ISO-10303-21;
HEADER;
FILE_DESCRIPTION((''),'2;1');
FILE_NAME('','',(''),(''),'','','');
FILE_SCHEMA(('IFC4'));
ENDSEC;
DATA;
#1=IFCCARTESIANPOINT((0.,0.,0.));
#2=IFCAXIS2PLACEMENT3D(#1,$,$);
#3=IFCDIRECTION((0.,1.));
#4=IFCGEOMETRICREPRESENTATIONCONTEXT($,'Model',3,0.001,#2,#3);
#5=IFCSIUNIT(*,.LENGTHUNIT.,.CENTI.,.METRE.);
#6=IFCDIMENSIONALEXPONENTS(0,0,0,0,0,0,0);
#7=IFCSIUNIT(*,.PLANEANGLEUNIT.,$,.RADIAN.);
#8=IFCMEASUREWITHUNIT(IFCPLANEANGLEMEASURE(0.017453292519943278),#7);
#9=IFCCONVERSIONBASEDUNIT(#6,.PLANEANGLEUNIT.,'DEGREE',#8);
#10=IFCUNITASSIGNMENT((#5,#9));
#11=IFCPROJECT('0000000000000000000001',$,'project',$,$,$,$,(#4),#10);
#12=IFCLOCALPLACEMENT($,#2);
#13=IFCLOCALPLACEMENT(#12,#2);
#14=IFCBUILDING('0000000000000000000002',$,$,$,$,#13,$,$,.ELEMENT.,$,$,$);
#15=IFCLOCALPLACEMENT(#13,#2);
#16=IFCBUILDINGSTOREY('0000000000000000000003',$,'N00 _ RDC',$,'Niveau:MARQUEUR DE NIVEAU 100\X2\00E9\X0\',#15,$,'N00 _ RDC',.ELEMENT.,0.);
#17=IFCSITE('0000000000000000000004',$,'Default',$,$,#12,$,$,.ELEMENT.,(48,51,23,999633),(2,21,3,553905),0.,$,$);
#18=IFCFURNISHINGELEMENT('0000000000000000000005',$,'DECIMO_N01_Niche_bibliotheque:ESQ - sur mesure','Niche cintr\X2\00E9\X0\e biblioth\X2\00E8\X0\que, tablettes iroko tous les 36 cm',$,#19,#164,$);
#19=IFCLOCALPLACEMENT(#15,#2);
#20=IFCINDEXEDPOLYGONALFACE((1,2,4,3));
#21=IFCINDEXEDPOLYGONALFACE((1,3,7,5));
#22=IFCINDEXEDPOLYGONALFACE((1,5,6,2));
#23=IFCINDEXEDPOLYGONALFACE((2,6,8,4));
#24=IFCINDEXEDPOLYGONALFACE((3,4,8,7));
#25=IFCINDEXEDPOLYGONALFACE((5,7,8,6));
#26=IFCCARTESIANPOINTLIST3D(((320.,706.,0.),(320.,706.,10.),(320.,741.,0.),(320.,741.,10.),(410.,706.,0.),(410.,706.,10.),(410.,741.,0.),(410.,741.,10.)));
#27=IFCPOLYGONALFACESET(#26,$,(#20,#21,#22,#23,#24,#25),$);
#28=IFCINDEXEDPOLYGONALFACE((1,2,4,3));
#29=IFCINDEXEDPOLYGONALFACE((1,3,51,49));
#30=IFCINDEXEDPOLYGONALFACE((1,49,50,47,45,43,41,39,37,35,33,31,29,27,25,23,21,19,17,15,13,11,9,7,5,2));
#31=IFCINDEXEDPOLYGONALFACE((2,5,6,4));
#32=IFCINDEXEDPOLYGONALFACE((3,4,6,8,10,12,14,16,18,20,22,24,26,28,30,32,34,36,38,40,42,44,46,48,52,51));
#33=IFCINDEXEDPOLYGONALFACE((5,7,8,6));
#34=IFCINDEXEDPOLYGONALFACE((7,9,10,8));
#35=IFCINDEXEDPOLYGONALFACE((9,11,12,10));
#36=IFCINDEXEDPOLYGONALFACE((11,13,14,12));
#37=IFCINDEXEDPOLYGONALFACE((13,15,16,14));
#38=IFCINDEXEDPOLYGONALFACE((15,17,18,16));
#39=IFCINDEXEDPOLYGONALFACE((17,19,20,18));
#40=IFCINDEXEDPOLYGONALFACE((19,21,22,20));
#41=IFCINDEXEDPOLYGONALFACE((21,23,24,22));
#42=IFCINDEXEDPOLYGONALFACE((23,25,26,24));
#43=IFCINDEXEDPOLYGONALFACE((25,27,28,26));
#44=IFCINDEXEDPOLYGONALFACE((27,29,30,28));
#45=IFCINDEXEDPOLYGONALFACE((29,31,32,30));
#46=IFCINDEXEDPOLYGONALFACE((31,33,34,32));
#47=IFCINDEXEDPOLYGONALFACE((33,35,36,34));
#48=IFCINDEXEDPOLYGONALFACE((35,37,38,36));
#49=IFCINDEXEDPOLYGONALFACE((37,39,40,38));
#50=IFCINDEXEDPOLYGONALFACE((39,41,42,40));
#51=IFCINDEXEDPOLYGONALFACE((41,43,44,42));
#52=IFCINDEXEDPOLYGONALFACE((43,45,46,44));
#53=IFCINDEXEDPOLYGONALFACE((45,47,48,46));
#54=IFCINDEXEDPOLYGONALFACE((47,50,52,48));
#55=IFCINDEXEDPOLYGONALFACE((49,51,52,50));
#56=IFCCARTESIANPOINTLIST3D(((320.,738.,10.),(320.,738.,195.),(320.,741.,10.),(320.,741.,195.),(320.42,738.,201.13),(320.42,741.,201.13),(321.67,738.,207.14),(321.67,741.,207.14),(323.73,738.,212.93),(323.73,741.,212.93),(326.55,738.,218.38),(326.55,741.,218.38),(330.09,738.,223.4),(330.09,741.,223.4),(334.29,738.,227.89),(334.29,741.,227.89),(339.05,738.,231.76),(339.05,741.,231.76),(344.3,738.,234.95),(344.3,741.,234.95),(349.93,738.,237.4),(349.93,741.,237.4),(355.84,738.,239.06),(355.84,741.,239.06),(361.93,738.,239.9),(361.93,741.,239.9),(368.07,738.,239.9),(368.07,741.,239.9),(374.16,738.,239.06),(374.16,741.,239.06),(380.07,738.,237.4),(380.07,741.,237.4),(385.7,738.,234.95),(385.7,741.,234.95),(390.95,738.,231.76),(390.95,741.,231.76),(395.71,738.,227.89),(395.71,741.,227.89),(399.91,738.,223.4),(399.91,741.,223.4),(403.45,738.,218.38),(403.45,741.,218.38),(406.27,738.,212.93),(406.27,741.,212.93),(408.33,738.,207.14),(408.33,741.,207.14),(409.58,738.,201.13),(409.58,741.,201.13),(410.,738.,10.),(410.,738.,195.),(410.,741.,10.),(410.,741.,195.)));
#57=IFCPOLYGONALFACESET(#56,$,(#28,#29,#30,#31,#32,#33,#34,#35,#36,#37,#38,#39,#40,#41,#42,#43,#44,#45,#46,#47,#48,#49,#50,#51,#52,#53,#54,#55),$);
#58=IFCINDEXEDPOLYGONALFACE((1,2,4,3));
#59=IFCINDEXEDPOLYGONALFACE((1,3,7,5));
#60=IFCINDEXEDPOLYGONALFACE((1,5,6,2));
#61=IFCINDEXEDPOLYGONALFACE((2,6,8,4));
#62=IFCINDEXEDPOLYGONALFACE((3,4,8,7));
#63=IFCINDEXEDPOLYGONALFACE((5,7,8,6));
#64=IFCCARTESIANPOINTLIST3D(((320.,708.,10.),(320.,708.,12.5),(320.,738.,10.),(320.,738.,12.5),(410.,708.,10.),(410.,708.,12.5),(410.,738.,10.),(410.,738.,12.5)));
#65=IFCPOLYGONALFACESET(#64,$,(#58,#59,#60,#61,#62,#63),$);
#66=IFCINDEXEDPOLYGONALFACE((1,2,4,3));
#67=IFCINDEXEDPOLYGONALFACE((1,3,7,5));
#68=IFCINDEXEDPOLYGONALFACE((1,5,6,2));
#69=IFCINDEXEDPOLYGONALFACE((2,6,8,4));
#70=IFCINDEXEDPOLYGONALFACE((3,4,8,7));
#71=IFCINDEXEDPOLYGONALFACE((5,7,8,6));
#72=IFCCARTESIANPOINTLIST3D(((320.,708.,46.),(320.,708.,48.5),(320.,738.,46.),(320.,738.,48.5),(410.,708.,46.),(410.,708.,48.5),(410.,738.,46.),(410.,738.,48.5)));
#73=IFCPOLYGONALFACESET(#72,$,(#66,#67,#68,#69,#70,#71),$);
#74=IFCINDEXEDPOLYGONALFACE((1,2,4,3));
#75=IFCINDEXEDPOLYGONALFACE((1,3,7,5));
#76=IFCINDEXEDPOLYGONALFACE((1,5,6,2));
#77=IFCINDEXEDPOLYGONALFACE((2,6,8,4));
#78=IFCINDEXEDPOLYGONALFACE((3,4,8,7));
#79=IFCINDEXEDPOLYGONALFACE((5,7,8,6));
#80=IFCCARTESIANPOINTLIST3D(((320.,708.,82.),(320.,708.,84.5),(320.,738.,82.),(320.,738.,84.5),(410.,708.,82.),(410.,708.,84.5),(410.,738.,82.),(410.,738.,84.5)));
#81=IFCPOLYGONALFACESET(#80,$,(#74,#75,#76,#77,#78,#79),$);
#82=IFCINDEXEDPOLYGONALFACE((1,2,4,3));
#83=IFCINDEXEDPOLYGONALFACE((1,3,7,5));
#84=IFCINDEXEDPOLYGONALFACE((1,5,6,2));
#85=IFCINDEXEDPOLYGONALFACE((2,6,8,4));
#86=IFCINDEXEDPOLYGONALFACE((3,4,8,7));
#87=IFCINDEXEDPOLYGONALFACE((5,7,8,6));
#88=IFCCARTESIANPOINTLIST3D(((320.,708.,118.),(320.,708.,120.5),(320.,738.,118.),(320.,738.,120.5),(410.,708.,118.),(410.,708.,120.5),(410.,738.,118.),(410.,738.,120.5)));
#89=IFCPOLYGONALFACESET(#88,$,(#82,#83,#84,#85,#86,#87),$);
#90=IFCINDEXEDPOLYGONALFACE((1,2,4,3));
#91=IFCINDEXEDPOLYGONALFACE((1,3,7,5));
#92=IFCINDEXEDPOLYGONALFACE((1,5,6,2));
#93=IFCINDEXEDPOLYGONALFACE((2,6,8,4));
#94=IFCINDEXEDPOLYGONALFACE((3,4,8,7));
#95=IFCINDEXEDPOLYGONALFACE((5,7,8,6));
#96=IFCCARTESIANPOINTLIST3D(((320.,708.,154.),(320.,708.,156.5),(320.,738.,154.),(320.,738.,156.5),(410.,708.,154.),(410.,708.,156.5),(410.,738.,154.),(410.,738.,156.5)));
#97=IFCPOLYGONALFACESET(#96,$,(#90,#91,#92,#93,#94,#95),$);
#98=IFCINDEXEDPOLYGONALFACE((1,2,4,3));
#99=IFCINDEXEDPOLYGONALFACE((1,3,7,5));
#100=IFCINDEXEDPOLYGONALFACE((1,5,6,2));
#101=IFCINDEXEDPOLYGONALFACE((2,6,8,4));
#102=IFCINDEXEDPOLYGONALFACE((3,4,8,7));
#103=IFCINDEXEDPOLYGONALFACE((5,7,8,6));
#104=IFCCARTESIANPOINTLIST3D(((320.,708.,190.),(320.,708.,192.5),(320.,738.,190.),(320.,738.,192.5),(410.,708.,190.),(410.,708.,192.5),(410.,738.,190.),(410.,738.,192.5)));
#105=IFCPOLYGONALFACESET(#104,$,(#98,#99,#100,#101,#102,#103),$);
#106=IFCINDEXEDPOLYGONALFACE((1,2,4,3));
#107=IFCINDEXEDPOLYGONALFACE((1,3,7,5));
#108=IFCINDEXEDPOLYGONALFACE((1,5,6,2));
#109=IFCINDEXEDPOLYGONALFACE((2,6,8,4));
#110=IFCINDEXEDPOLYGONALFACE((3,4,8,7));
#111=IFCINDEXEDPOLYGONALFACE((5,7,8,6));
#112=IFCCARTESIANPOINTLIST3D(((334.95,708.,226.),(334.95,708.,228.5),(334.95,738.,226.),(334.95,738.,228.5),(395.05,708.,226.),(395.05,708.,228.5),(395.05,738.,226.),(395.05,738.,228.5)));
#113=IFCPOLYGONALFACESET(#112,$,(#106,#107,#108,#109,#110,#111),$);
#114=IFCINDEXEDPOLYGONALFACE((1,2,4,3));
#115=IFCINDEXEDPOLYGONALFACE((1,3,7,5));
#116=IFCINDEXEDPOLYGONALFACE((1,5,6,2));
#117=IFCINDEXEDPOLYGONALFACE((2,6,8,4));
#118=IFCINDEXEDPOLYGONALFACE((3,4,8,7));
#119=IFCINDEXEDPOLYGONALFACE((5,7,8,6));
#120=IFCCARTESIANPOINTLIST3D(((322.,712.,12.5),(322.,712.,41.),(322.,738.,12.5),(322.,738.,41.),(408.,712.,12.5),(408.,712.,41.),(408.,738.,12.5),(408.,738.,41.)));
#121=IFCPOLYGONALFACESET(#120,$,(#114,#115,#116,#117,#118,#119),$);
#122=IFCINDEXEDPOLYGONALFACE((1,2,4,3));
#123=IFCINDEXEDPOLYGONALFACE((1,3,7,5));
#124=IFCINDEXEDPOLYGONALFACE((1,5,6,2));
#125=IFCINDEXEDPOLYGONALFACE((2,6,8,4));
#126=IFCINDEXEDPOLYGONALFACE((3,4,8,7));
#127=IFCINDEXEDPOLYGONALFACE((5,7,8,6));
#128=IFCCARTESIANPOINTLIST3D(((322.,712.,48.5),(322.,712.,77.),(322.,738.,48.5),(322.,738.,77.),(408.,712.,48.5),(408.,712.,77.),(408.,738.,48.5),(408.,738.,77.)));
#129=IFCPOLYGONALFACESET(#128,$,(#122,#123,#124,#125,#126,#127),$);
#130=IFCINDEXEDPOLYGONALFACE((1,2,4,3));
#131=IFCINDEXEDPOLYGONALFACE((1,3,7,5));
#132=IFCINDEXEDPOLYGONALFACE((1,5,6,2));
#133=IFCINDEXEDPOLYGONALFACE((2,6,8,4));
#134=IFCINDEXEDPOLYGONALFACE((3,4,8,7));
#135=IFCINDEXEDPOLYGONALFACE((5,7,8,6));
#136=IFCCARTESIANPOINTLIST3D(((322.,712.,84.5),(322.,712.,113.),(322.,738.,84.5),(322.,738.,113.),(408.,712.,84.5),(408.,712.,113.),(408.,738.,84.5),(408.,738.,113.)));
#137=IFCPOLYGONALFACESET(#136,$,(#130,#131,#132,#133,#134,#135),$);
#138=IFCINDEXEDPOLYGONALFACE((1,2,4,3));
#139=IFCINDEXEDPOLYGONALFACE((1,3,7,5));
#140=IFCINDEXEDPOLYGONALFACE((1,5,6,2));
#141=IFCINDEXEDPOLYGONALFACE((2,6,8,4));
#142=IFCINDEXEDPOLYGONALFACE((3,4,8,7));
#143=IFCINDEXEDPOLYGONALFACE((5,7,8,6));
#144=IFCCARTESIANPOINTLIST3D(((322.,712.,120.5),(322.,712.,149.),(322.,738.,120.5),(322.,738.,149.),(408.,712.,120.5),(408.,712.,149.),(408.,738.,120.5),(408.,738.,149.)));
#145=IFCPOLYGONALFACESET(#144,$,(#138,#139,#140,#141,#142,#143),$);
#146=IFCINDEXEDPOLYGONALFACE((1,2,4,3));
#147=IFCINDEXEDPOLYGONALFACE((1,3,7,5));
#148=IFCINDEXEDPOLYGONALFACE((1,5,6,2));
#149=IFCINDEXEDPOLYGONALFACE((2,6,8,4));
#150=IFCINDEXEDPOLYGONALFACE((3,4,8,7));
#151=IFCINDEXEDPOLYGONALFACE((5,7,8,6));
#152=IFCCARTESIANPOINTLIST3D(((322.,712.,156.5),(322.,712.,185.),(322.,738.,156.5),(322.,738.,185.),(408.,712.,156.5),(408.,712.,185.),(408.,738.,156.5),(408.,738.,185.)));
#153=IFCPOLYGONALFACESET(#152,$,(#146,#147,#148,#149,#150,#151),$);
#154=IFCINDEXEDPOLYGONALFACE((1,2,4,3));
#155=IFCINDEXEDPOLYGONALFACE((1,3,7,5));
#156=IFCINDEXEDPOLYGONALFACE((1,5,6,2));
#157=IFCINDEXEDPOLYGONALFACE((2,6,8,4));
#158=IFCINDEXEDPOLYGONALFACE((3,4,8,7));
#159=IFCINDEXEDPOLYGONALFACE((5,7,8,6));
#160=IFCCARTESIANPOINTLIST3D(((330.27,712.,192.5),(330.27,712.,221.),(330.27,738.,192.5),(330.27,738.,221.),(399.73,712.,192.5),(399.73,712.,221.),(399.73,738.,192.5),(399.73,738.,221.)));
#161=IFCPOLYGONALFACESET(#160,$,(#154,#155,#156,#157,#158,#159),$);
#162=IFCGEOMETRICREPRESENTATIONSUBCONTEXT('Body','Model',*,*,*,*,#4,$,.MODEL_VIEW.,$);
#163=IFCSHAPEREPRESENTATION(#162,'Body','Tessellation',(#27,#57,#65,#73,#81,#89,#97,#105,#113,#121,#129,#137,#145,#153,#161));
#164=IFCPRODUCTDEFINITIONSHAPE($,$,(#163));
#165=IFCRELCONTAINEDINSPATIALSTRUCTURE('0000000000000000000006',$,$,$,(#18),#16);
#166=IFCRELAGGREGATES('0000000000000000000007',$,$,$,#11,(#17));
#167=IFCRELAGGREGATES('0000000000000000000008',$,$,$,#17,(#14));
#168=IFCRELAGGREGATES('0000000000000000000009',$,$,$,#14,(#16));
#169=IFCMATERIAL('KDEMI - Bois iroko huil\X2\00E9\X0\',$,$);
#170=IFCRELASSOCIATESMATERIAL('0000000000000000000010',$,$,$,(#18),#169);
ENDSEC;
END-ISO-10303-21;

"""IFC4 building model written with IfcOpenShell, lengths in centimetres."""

from ifc_helpers import new_model, entity, si_unit, converted_unit, direction, frame, frame_2d, origin, origin_with_axes, place, context, subcontext, project, spatial, polyline, rectangle, outline, extrude, material, element, save


model = new_model("IFC4")

# Units and contexts
model_context = context("Model", 3, precision=0.001, world=origin(), true_north=direction((0.0, 1.0)))
body_context = subcontext(model_context, "Body", "Model", "MODEL_VIEW")
ifc_project = project(units=[si_unit("LENGTHUNIT", "METRE", prefix="CENTI"), converted_unit("PLANEANGLEUNIT", "DEGREE", entity("IfcPlaneAngleMeasure", 0.017453292519943278), si_unit("PLANEANGLEUNIT", "RADIAN"), dimensions=[0, 0, 0, 0, 0, 0, 0])], contexts=[model_context])

# Site, building, storey
site_placement = place(None, origin())
site = spatial("IfcSite", under=ifc_project, at=site_placement, Name="Default", CompositionType="ELEMENT", RefLatitude=(48, 51, 23, 999633), RefLongitude=(2, 21, 3, 553905), RefElevation=0.0)
building_placement = place(site_placement, origin())
building = spatial("IfcBuilding", under=site, at=building_placement, CompositionType="ELEMENT")
storey_placement = place(building_placement, origin())
storey = spatial("IfcBuildingStorey", under=building, at=storey_placement, Name="N00 _ RDC", ObjectType="Niveau:MARQUEUR DE NIVEAU 100é", LongName="N00 _ RDC", CompositionType="ELEMENT", Elevation=0.0)

# Furnishing element
ifc_material_1 = material(Name="KDEMI - Bois iroko huilé")
furnishing_1_placement = place(storey_placement, origin_with_axes())
element("IfcFurnishingElement", 1, at=furnishing_1_placement, inside=storey, material=ifc_material_1, Name="DECIMO_N01_Niche_bibliotheque:ESQ - sur mesure", Description="Niche cintrée bibliothèque, tablettes iroko tous les 36 cm", context=body_context, shape_type="SweptSolid", body=[
    extrude(rectangle(XDim=90.0, YDim=35.0, at=frame_2d((365.0, 723.5))), origin(), (0.0, 0.0, 1.0), 10.0),
    extrude(outline(polyline([(320.0, 10.0), (410.0, 10.0), (410.0, 195.0), (409.58, 201.13), (408.33, 207.14), (406.27, 212.93), (403.45, 218.38), (399.91, 223.4), (395.71, 227.89), (390.95, 231.76), (385.7, 234.95), (380.07, 237.4), (374.16, 239.06), (368.07, 239.9), (361.93, 239.9), (355.84, 239.06), (349.93, 237.4), (344.3, 234.95), (339.05, 231.76), (334.29, 227.89), (330.09, 223.4), (326.55, 218.38), (323.73, 212.93), (321.67, 207.14), (320.42, 201.13), (320.0, 195.0), (320.0, 10.0)])), frame((0.0, 741.0, 0.0), z_axis=(0.0, -1.0, 0.0), x_axis=(1.0, 0.0, 0.0)), (0.0, 0.0, 1.0), 3.0),
    extrude(rectangle(XDim=90.0, YDim=30.0, at=frame_2d((365.0, 723.0))), frame((0.0, 0.0, 10.0)), (0.0, 0.0, 1.0), 2.5),
    extrude(rectangle(XDim=90.0, YDim=30.0, at=frame_2d((365.0, 723.0))), frame((0.0, 0.0, 46.0)), (0.0, 0.0, 1.0), 2.5),
    extrude(rectangle(XDim=90.0, YDim=30.0, at=frame_2d((365.0, 723.0))), frame((0.0, 0.0, 82.0)), (0.0, 0.0, 1.0), 2.5),
    extrude(rectangle(XDim=90.0, YDim=30.0, at=frame_2d((365.0, 723.0))), frame((0.0, 0.0, 118.0)), (0.0, 0.0, 1.0), 2.5),
    extrude(rectangle(XDim=90.0, YDim=30.0, at=frame_2d((365.0, 723.0))), frame((0.0, 0.0, 154.0)), (0.0, 0.0, 1.0), 2.5),
    extrude(rectangle(XDim=90.0, YDim=30.0, at=frame_2d((365.0, 723.0))), frame((0.0, 0.0, 190.0)), (0.0, 0.0, 1.0), 2.5),
    extrude(rectangle(XDim=60.09, YDim=30.0, at=frame_2d((365.0, 723.0))), frame((0.0, 0.0, 226.0)), (0.0, 0.0, 1.0), 2.5),
    extrude(rectangle(XDim=86.0, YDim=26.0, at=frame_2d((365.0, 725.0))), frame((0.0, 0.0, 12.5)), (0.0, 0.0, 1.0), 28.5),
    extrude(rectangle(XDim=86.0, YDim=26.0, at=frame_2d((365.0, 725.0))), frame((0.0, 0.0, 48.5)), (0.0, 0.0, 1.0), 28.5),
    extrude(rectangle(XDim=86.0, YDim=26.0, at=frame_2d((365.0, 725.0))), frame((0.0, 0.0, 84.5)), (0.0, 0.0, 1.0), 28.5),
    extrude(rectangle(XDim=86.0, YDim=26.0, at=frame_2d((365.0, 725.0))), frame((0.0, 0.0, 120.5)), (0.0, 0.0, 1.0), 28.5),
    extrude(rectangle(XDim=86.0, YDim=26.0, at=frame_2d((365.0, 725.0))), frame((0.0, 0.0, 156.5)), (0.0, 0.0, 1.0), 28.5),
    extrude(rectangle(XDim=69.46, YDim=26.0, at=frame_2d((365.0, 725.0))), frame((0.0, 0.0, 192.5)), (0.0, 0.0, 1.0), 28.5),
])

save(model, "model.ifc")
